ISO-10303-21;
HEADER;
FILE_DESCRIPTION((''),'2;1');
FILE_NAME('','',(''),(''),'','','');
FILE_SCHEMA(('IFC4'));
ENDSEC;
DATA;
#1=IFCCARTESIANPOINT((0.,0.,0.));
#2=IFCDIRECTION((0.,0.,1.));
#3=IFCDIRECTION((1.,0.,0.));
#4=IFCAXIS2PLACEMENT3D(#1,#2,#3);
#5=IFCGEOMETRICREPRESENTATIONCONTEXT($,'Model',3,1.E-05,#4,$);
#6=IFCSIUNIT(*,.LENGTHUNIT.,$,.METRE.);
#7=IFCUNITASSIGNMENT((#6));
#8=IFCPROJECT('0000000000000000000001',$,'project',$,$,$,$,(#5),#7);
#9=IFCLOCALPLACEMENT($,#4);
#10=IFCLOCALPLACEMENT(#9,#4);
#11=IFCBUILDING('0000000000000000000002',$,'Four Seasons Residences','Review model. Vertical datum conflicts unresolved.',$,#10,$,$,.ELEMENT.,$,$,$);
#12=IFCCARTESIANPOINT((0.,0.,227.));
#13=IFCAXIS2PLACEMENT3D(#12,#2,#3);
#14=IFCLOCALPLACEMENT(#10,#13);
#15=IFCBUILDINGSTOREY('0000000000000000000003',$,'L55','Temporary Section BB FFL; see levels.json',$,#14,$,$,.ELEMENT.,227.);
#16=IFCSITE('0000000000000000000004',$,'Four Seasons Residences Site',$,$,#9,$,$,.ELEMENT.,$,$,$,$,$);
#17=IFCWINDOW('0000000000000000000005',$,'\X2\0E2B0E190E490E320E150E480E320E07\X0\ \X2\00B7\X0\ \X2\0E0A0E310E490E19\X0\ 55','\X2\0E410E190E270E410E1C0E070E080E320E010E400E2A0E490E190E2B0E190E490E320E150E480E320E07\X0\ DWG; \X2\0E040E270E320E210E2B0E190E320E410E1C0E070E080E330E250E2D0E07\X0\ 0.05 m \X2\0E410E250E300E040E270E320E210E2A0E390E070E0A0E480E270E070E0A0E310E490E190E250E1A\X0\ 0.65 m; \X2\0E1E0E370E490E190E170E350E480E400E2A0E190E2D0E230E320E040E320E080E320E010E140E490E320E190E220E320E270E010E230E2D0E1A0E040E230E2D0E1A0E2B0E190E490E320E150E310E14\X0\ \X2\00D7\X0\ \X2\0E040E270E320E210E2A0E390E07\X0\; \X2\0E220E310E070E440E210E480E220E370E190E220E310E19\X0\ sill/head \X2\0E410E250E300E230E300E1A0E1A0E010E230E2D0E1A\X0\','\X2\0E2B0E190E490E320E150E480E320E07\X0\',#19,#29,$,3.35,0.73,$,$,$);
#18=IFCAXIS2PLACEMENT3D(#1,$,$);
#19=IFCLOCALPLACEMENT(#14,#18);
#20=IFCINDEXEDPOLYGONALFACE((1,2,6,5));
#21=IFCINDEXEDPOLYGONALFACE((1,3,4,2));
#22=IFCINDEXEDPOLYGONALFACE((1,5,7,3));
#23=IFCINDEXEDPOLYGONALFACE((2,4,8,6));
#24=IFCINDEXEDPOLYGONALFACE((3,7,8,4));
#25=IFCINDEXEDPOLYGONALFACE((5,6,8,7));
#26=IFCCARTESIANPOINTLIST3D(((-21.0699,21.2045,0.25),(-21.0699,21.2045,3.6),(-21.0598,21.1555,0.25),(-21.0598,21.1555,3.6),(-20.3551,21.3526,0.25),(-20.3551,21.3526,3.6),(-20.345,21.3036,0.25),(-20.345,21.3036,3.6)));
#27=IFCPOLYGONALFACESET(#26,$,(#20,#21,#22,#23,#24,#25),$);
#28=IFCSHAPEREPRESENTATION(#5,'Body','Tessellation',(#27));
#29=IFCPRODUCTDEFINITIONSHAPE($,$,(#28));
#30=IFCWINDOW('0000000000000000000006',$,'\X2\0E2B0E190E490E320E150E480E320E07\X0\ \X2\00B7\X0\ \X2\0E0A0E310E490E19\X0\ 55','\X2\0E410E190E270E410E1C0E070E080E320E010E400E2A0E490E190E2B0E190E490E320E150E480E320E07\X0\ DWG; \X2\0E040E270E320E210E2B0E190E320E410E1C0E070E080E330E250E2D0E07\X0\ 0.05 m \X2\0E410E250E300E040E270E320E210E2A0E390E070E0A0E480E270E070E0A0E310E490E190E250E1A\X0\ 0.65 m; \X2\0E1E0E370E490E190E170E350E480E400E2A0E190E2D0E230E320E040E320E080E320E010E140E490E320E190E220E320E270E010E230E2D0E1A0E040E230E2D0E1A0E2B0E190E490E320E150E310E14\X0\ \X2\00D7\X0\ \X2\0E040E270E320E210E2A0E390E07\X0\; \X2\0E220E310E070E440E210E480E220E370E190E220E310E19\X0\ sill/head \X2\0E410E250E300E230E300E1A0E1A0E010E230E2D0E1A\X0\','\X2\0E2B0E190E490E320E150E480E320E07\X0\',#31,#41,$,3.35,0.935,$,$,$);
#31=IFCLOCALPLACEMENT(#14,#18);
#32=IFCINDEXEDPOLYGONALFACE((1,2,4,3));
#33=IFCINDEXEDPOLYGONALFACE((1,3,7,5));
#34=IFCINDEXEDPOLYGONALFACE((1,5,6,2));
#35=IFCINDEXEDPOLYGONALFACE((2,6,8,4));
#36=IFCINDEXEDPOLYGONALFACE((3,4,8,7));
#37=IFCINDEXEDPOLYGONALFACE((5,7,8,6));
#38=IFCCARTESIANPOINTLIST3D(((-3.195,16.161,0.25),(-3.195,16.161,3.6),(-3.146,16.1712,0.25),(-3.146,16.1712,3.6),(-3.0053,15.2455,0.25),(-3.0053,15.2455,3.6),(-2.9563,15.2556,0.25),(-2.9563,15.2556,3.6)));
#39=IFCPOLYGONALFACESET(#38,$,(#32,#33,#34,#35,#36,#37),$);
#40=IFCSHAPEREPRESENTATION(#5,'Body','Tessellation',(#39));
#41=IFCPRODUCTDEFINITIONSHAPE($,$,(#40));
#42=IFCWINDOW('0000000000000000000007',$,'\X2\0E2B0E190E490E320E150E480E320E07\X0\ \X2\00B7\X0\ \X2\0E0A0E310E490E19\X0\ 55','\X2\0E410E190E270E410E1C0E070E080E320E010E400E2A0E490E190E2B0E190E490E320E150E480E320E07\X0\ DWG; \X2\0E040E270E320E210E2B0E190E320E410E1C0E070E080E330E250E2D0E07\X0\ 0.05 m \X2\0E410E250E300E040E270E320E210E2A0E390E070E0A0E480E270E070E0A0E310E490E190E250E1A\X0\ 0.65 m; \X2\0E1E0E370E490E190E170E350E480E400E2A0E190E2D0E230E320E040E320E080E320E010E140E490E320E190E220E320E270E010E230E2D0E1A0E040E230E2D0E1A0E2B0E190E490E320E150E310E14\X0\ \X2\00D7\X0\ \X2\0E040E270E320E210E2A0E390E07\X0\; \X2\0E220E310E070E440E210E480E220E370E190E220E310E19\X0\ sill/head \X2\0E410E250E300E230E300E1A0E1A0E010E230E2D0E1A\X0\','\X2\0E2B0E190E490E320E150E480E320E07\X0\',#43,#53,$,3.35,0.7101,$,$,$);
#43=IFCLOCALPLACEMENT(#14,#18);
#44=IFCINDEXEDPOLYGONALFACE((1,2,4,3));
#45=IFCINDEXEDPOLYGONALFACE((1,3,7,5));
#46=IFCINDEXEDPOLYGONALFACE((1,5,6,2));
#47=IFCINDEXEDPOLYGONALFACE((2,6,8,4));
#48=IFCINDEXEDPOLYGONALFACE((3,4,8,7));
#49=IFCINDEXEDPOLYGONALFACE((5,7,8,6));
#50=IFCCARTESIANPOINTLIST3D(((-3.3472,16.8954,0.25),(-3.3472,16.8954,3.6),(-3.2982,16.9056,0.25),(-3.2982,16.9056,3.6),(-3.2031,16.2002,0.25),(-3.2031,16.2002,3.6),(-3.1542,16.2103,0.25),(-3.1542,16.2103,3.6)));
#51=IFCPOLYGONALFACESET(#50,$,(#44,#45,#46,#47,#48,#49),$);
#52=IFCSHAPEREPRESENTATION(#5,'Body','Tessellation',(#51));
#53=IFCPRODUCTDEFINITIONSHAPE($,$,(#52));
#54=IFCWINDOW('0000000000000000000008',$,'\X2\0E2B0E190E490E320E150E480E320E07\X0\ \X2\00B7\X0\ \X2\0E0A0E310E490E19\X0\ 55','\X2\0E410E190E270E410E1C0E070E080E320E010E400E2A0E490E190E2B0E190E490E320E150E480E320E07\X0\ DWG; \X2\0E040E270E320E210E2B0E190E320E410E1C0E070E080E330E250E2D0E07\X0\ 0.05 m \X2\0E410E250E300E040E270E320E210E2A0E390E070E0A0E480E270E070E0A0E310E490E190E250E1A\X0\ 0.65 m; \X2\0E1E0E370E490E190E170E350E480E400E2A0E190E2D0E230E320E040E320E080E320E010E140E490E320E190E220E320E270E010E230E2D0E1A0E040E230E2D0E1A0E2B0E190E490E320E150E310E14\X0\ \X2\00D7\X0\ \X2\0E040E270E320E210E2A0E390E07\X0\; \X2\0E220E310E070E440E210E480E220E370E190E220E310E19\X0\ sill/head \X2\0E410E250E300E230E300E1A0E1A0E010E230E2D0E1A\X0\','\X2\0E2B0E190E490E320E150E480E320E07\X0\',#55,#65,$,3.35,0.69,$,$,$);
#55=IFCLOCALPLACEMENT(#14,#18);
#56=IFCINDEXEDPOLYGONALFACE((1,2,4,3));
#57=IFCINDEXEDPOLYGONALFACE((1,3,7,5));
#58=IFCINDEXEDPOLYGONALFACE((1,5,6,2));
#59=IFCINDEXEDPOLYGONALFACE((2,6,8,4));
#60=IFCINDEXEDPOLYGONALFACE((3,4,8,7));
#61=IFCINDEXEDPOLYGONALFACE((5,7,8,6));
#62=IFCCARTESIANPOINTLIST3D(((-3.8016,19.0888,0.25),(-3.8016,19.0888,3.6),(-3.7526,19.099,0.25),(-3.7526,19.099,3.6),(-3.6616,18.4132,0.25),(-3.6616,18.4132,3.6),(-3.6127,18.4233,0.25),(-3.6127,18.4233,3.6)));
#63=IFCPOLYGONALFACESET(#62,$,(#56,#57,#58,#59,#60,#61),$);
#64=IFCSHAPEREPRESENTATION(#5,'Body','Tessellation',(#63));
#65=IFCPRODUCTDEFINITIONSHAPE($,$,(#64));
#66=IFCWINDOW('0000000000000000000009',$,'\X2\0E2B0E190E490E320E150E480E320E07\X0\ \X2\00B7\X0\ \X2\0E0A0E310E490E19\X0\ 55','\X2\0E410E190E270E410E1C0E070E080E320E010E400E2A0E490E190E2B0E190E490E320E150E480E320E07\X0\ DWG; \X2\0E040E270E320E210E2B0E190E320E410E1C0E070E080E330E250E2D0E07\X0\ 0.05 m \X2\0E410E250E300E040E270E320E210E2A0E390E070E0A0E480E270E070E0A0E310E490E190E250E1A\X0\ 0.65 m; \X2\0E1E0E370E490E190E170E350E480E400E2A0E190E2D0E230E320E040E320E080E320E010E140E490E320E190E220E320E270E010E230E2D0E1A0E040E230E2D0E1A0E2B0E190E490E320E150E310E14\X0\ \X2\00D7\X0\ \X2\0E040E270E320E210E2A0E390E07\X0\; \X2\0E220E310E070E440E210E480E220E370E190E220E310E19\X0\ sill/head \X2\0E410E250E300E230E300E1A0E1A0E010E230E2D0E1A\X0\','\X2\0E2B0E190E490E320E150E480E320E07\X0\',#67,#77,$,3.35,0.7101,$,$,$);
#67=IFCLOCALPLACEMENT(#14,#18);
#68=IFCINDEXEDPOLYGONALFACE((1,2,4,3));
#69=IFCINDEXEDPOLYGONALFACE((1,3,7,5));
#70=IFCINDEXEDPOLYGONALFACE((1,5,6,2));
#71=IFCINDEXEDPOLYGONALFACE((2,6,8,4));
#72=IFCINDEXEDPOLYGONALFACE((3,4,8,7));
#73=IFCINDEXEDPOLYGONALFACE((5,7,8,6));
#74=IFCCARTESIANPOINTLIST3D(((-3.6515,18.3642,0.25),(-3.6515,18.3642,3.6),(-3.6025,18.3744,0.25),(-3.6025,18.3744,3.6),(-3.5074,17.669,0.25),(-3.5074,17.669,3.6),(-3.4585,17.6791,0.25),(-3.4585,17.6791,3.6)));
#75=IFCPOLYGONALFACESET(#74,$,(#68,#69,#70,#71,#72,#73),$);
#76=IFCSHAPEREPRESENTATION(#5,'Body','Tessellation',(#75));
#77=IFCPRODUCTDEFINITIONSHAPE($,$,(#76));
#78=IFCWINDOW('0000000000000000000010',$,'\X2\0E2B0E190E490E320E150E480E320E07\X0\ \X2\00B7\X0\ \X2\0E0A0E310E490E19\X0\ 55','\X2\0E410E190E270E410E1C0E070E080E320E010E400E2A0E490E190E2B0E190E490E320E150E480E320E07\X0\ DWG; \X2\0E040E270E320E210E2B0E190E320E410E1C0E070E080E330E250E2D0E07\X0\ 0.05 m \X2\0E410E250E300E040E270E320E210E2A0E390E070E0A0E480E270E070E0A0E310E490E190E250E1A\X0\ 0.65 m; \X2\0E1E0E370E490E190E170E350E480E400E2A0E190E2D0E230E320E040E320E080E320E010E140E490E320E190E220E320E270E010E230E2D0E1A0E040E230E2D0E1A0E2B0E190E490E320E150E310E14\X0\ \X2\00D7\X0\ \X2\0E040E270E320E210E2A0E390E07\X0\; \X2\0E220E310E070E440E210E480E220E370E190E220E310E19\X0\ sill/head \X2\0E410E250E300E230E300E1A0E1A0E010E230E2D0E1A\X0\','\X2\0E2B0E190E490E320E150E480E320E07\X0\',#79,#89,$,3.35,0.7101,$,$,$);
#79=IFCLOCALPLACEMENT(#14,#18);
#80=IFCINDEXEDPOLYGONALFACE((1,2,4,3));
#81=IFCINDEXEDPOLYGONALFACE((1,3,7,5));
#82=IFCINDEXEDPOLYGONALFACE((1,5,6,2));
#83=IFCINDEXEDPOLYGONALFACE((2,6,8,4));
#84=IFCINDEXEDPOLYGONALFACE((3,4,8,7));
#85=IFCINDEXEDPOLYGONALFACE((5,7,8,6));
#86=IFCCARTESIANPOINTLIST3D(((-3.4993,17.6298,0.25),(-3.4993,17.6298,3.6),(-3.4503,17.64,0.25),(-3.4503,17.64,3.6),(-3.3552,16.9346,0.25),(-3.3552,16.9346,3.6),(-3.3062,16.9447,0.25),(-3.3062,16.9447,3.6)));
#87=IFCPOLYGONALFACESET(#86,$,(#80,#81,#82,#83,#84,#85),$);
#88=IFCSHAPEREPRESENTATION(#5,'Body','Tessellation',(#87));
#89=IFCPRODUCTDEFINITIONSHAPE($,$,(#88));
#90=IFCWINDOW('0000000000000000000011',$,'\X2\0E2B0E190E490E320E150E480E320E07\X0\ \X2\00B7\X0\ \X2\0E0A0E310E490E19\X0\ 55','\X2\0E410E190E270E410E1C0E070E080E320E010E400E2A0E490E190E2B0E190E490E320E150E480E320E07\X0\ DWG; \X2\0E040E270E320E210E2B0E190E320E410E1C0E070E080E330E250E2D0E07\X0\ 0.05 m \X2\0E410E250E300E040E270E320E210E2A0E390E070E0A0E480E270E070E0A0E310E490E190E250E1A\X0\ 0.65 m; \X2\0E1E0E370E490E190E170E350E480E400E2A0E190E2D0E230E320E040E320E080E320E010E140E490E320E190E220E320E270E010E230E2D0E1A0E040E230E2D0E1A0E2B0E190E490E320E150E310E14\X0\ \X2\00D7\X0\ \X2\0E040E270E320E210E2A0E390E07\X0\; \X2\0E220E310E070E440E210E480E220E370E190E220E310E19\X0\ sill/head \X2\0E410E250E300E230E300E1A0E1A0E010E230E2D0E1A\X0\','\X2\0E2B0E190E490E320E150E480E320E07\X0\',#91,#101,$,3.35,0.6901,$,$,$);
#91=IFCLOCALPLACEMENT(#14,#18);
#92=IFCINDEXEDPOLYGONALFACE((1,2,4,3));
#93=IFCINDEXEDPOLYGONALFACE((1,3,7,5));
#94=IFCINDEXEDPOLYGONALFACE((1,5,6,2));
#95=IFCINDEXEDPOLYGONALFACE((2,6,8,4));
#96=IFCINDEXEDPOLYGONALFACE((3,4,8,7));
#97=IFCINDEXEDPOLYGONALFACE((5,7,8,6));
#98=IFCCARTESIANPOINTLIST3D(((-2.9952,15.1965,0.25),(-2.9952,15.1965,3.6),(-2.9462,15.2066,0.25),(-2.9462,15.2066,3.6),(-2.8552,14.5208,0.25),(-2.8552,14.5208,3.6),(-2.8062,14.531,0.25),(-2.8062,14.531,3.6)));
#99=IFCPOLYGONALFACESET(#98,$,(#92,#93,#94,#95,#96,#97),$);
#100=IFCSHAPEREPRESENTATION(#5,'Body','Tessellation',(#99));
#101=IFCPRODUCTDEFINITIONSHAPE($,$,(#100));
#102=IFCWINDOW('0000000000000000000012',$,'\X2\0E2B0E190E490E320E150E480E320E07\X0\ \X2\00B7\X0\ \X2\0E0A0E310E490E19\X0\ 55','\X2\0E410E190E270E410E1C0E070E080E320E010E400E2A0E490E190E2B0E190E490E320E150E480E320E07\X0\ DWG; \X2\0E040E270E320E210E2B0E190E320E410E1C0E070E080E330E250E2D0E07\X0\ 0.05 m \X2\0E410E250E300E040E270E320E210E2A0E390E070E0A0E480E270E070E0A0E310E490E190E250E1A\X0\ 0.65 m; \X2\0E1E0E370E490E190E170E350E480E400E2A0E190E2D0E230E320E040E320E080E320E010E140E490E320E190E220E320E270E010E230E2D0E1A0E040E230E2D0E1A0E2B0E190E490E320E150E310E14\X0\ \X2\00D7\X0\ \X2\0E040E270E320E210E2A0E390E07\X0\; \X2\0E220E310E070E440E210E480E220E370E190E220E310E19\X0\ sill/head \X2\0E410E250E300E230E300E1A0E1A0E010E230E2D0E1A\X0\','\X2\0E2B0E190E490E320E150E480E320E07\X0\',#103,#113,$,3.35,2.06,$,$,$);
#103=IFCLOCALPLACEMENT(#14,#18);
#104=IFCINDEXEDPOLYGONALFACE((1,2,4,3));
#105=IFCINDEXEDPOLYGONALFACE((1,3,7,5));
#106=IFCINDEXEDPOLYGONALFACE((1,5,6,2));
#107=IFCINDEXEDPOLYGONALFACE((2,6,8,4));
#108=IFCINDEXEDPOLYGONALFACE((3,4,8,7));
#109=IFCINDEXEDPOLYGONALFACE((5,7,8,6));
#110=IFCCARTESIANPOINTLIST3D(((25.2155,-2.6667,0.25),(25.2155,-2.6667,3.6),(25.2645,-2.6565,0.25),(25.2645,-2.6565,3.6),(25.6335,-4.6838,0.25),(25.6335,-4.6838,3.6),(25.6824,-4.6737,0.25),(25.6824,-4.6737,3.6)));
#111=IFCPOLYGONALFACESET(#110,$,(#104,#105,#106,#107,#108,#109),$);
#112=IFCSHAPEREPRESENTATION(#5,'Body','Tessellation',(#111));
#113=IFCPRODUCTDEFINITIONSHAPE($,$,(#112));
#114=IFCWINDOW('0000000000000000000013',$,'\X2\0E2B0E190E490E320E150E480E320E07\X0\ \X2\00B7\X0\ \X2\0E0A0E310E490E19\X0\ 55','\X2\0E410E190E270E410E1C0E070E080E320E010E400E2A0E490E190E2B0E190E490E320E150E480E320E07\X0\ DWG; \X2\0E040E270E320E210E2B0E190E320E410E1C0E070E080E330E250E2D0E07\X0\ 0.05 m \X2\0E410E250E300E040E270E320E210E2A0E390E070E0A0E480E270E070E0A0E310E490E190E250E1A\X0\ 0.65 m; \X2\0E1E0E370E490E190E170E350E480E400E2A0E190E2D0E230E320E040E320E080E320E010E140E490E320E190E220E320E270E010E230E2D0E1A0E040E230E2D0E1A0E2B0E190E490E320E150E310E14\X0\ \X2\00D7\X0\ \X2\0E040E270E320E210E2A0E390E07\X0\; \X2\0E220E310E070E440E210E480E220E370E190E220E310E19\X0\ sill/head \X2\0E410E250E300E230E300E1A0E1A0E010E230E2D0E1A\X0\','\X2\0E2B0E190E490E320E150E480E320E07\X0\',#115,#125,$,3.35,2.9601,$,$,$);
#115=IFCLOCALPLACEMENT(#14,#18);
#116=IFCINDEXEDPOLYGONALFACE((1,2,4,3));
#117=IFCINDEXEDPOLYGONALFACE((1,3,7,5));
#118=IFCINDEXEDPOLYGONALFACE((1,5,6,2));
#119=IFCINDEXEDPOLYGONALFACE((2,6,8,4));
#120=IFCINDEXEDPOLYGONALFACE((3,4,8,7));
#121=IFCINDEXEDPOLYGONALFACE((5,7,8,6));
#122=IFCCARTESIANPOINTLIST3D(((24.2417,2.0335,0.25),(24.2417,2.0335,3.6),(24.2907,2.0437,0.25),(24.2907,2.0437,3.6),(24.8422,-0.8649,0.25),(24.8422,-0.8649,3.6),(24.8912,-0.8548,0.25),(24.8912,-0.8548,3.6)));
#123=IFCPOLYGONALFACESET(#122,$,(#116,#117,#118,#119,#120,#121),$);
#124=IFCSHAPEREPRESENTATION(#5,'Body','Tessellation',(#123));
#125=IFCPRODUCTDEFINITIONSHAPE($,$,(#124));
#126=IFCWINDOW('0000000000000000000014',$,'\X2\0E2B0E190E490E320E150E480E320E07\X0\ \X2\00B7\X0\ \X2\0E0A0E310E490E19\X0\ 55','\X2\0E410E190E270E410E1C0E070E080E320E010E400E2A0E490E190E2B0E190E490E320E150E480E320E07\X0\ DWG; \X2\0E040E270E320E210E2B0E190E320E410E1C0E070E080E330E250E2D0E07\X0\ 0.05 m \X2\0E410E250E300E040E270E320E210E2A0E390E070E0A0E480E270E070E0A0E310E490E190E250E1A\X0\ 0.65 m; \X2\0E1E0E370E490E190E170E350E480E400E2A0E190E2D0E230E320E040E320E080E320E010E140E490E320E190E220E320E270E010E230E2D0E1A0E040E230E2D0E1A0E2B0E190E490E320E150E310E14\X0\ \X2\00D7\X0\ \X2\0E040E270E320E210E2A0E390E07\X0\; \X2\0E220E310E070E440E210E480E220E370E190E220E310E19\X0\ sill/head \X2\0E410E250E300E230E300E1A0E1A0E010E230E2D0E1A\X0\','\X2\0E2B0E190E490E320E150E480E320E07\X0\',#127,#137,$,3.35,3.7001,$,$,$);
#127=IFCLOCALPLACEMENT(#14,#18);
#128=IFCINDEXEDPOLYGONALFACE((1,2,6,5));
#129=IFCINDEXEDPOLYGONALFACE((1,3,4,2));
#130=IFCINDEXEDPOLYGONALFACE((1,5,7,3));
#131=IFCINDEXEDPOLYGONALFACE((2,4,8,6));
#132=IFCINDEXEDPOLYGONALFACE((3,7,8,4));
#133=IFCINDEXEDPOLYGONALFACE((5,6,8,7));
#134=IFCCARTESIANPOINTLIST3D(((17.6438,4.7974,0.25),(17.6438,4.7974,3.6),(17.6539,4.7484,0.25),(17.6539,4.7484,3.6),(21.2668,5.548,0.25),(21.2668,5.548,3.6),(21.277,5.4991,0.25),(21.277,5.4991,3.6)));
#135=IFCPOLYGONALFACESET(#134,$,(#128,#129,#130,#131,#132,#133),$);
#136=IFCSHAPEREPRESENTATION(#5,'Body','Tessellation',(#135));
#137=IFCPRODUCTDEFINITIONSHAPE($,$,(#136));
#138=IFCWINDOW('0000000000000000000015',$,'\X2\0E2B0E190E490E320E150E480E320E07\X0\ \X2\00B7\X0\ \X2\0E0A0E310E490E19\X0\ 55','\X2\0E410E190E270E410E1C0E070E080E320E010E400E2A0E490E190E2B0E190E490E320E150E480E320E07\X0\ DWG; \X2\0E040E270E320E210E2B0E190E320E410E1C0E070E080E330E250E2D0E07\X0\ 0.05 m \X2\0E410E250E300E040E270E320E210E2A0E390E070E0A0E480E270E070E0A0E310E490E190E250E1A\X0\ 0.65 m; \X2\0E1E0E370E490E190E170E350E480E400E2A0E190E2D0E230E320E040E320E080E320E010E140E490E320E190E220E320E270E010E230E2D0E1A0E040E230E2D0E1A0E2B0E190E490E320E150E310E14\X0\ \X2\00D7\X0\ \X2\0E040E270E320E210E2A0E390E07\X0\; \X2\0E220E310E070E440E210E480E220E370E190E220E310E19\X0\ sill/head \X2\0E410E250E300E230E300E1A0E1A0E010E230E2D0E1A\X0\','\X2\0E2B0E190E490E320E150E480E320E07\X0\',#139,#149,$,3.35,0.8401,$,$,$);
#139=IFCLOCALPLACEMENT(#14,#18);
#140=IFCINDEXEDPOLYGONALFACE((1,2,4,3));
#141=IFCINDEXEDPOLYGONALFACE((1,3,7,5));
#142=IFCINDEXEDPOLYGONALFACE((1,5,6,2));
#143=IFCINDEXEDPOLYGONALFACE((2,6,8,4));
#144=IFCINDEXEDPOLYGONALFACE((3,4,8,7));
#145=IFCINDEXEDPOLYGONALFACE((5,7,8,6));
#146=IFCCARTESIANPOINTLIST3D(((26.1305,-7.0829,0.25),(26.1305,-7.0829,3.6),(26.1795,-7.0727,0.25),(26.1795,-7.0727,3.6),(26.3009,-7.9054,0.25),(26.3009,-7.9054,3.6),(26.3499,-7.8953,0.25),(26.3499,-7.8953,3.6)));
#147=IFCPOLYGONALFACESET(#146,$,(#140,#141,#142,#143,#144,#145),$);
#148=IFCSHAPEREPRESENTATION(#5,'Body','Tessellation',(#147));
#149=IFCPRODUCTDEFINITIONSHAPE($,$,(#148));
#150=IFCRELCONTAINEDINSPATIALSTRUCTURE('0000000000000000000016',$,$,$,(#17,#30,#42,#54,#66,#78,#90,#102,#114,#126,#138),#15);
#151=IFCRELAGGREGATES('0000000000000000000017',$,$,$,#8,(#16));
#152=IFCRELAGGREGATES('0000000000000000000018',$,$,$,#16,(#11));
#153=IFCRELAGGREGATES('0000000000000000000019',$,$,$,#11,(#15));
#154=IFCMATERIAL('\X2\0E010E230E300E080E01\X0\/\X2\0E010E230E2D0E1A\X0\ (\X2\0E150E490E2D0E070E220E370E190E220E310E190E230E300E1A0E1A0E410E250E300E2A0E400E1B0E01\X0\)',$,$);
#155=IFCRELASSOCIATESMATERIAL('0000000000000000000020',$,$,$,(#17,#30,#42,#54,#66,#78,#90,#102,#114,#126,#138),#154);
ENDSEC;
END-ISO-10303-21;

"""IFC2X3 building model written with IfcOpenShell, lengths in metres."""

from ifc_helpers import new_model, si_unit, frame, origin_with_axes, place, context, project, spatial, polyline, outline, extrude, material, element, save


model = new_model("IFC2X3")

# Units and contexts
model_context = context("Model", 3, precision=1e-05, world=origin_with_axes())
ifc_project = project(units=[si_unit("LENGTHUNIT", "METRE")], contexts=[model_context])

# Site, building, storey
site_placement = place(None, origin_with_axes())
site = spatial("IfcSite", under=ifc_project, at=site_placement, Name="Four Seasons Residences Site", CompositionType="ELEMENT")
building_placement = place(site_placement, origin_with_axes())
building = spatial("IfcBuilding", under=site, at=building_placement, Name="Four Seasons Residences", Description="Review model. Vertical datum conflicts unresolved.", CompositionType="ELEMENT")
storey_placement = place(building_placement, frame((0.0, 0.0, 227.0), z_axis=(0.0, 0.0, 1.0), x_axis=(1.0, 0.0, 0.0)))
storey = spatial("IfcBuildingStorey", under=building, at=storey_placement, Name="L55", Description="Temporary Section BB FFL; see levels.json", CompositionType="ELEMENT", Elevation=227.0)

# Windows
ifc_material = material(Name="กระจก/กรอบ (ต้องยืนยันระบบและสเปก)")
window_1_placement = place(storey_placement, origin_with_axes())
element("IfcWindow", 1, at=window_1_placement, inside=storey, material=ifc_material, Name="หน้าต่าง · ชั้น 55", Description="แนวแผงจากเส้นหน้าต่าง DWG; ความหนาแผงจำลอง 0.05 m และความสูงช่วงชั้นลบ 0.65 m; พื้นที่เสนอราคาจากด้านยาวกรอบครอบหน้าตัด × ความสูง; ยังไม่ยืนยัน sill/head และระบบกรอบ", ObjectType="หน้าต่าง", OverallHeight=3.35, OverallWidth=0.73, context=model_context, shape_type="SweptSolid", body=[
    extrude(outline(polyline([(-21.0598, 21.1555), (-21.0699, 21.2045), (-20.3551, 21.3526), (-20.345, 21.3036), (-21.0598, 21.1555)])), frame((0.0, 0.0, 0.25), z_axis=(0.0, 0.0, 1.0), x_axis=(1.0, 0.0, 0.0)), (0.0, 0.0, 1.0), 3.35),
])
window_2_placement = place(storey_placement, origin_with_axes())
element("IfcWindow", 2, at=window_2_placement, inside=storey, material=ifc_material, Name="หน้าต่าง · ชั้น 55", Description="แนวแผงจากเส้นหน้าต่าง DWG; ความหนาแผงจำลอง 0.05 m และความสูงช่วงชั้นลบ 0.65 m; พื้นที่เสนอราคาจากด้านยาวกรอบครอบหน้าตัด × ความสูง; ยังไม่ยืนยัน sill/head และระบบกรอบ", ObjectType="หน้าต่าง", OverallHeight=3.35, OverallWidth=0.935, context=model_context, shape_type="SweptSolid", body=[
    extrude(outline(polyline([(-3.195, 16.161), (-3.146, 16.1712), (-2.9563, 15.2556), (-3.0053, 15.2455), (-3.195, 16.161)])), frame((0.0, 0.0, 0.25), z_axis=(0.0, 0.0, 1.0), x_axis=(1.0, 0.0, 0.0)), (0.0, 0.0, 1.0), 3.35),
])
window_3_placement = place(storey_placement, origin_with_axes())
element("IfcWindow", 3, at=window_3_placement, inside=storey, material=ifc_material, Name="หน้าต่าง · ชั้น 55", Description="แนวแผงจากเส้นหน้าต่าง DWG; ความหนาแผงจำลอง 0.05 m และความสูงช่วงชั้นลบ 0.65 m; พื้นที่เสนอราคาจากด้านยาวกรอบครอบหน้าตัด × ความสูง; ยังไม่ยืนยัน sill/head และระบบกรอบ", ObjectType="หน้าต่าง", OverallHeight=3.35, OverallWidth=0.7101, context=model_context, shape_type="SweptSolid", body=[
    extrude(outline(polyline([(-3.3472, 16.8954), (-3.2982, 16.9056), (-3.1542, 16.2103), (-3.2031, 16.2002), (-3.3472, 16.8954)])), frame((0.0, 0.0, 0.25), z_axis=(0.0, 0.0, 1.0), x_axis=(1.0, 0.0, 0.0)), (0.0, 0.0, 1.0), 3.35),
])
window_4_placement = place(storey_placement, origin_with_axes())
element("IfcWindow", 4, at=window_4_placement, inside=storey, material=ifc_material, Name="หน้าต่าง · ชั้น 55", Description="แนวแผงจากเส้นหน้าต่าง DWG; ความหนาแผงจำลอง 0.05 m และความสูงช่วงชั้นลบ 0.65 m; พื้นที่เสนอราคาจากด้านยาวกรอบครอบหน้าตัด × ความสูง; ยังไม่ยืนยัน sill/head และระบบกรอบ", ObjectType="หน้าต่าง", OverallHeight=3.35, OverallWidth=0.69, context=model_context, shape_type="SweptSolid", body=[
    extrude(outline(polyline([(-3.6127, 18.4233), (-3.6616, 18.4132), (-3.8016, 19.0888), (-3.7526, 19.099), (-3.6127, 18.4233)])), frame((0.0, 0.0, 0.25), z_axis=(0.0, 0.0, 1.0), x_axis=(1.0, 0.0, 0.0)), (0.0, 0.0, 1.0), 3.35),
])
window_5_placement = place(storey_placement, origin_with_axes())
element("IfcWindow", 5, at=window_5_placement, inside=storey, material=ifc_material, Name="หน้าต่าง · ชั้น 55", Description="แนวแผงจากเส้นหน้าต่าง DWG; ความหนาแผงจำลอง 0.05 m และความสูงช่วงชั้นลบ 0.65 m; พื้นที่เสนอราคาจากด้านยาวกรอบครอบหน้าตัด × ความสูง; ยังไม่ยืนยัน sill/head และระบบกรอบ", ObjectType="หน้าต่าง", OverallHeight=3.35, OverallWidth=0.7101, context=model_context, shape_type="SweptSolid", body=[
    extrude(outline(polyline([(-3.4585, 17.6791), (-3.5074, 17.669), (-3.6515, 18.3642), (-3.6025, 18.3744), (-3.4585, 17.6791)])), frame((0.0, 0.0, 0.25), z_axis=(0.0, 0.0, 1.0), x_axis=(1.0, 0.0, 0.0)), (0.0, 0.0, 1.0), 3.35),
])
window_6_placement = place(storey_placement, origin_with_axes())
element("IfcWindow", 6, at=window_6_placement, inside=storey, material=ifc_material, Name="หน้าต่าง · ชั้น 55", Description="แนวแผงจากเส้นหน้าต่าง DWG; ความหนาแผงจำลอง 0.05 m และความสูงช่วงชั้นลบ 0.65 m; พื้นที่เสนอราคาจากด้านยาวกรอบครอบหน้าตัด × ความสูง; ยังไม่ยืนยัน sill/head และระบบกรอบ", ObjectType="หน้าต่าง", OverallHeight=3.35, OverallWidth=0.7101, context=model_context, shape_type="SweptSolid", body=[
    extrude(outline(polyline([(-3.3062, 16.9447), (-3.3552, 16.9346), (-3.4993, 17.6298), (-3.4503, 17.64), (-3.3062, 16.9447)])), frame((0.0, 0.0, 0.25), z_axis=(0.0, 0.0, 1.0), x_axis=(1.0, 0.0, 0.0)), (0.0, 0.0, 1.0), 3.35),
])
window_7_placement = place(storey_placement, origin_with_axes())
element("IfcWindow", 7, at=window_7_placement, inside=storey, material=ifc_material, Name="หน้าต่าง · ชั้น 55", Description="แนวแผงจากเส้นหน้าต่าง DWG; ความหนาแผงจำลอง 0.05 m และความสูงช่วงชั้นลบ 0.65 m; พื้นที่เสนอราคาจากด้านยาวกรอบครอบหน้าตัด × ความสูง; ยังไม่ยืนยัน sill/head และระบบกรอบ", ObjectType="หน้าต่าง", OverallHeight=3.35, OverallWidth=0.6901, context=model_context, shape_type="SweptSolid", body=[
    extrude(outline(polyline([(-2.9952, 15.1965), (-2.9462, 15.2066), (-2.8062, 14.531), (-2.8552, 14.5208), (-2.9952, 15.1965)])), frame((0.0, 0.0, 0.25), z_axis=(0.0, 0.0, 1.0), x_axis=(1.0, 0.0, 0.0)), (0.0, 0.0, 1.0), 3.35),
])
window_8_placement = place(storey_placement, origin_with_axes())
element("IfcWindow", 8, at=window_8_placement, inside=storey, material=ifc_material, Name="หน้าต่าง · ชั้น 55", Description="แนวแผงจากเส้นหน้าต่าง DWG; ความหนาแผงจำลอง 0.05 m และความสูงช่วงชั้นลบ 0.65 m; พื้นที่เสนอราคาจากด้านยาวกรอบครอบหน้าตัด × ความสูง; ยังไม่ยืนยัน sill/head และระบบกรอบ", ObjectType="หน้าต่าง", OverallHeight=3.35, OverallWidth=2.06, context=model_context, shape_type="SweptSolid", body=[
    extrude(outline(polyline([(25.2155, -2.6667), (25.2645, -2.6565), (25.6824, -4.6737), (25.6335, -4.6838), (25.2155, -2.6667)])), frame((0.0, 0.0, 0.25), z_axis=(0.0, 0.0, 1.0), x_axis=(1.0, 0.0, 0.0)), (0.0, 0.0, 1.0), 3.35),
])
window_9_placement = place(storey_placement, origin_with_axes())
element("IfcWindow", 9, at=window_9_placement, inside=storey, material=ifc_material, Name="หน้าต่าง · ชั้น 55", Description="แนวแผงจากเส้นหน้าต่าง DWG; ความหนาแผงจำลอง 0.05 m และความสูงช่วงชั้นลบ 0.65 m; พื้นที่เสนอราคาจากด้านยาวกรอบครอบหน้าตัด × ความสูง; ยังไม่ยืนยัน sill/head และระบบกรอบ", ObjectType="หน้าต่าง", OverallHeight=3.35, OverallWidth=2.9601, context=model_context, shape_type="SweptSolid", body=[
    extrude(outline(polyline([(24.2417, 2.0335), (24.2907, 2.0437), (24.8912, -0.8548), (24.8422, -0.8649), (24.2417, 2.0335)])), frame((0.0, 0.0, 0.25), z_axis=(0.0, 0.0, 1.0), x_axis=(1.0, 0.0, 0.0)), (0.0, 0.0, 1.0), 3.35),
])
window_10_placement = place(storey_placement, origin_with_axes())
element("IfcWindow", 10, at=window_10_placement, inside=storey, material=ifc_material, Name="หน้าต่าง · ชั้น 55", Description="แนวแผงจากเส้นหน้าต่าง DWG; ความหนาแผงจำลอง 0.05 m และความสูงช่วงชั้นลบ 0.65 m; พื้นที่เสนอราคาจากด้านยาวกรอบครอบหน้าตัด × ความสูง; ยังไม่ยืนยัน sill/head และระบบกรอบ", ObjectType="หน้าต่าง", OverallHeight=3.35, OverallWidth=3.7001, context=model_context, shape_type="SweptSolid", body=[
    extrude(outline(polyline([(17.6539, 4.7484), (17.6438, 4.7974), (21.2668, 5.548), (21.277, 5.4991), (17.6539, 4.7484)])), frame((0.0, 0.0, 0.25), z_axis=(0.0, 0.0, 1.0), x_axis=(1.0, 0.0, 0.0)), (0.0, 0.0, 1.0), 3.35),
])
window_11_placement = place(storey_placement, origin_with_axes())
element("IfcWindow", 11, at=window_11_placement, inside=storey, material=ifc_material, Name="หน้าต่าง · ชั้น 55", Description="แนวแผงจากเส้นหน้าต่าง DWG; ความหนาแผงจำลอง 0.05 m และความสูงช่วงชั้นลบ 0.65 m; พื้นที่เสนอราคาจากด้านยาวกรอบครอบหน้าตัด × ความสูง; ยังไม่ยืนยัน sill/head และระบบกรอบ", ObjectType="หน้าต่าง", OverallHeight=3.35, OverallWidth=0.8401, context=model_context, shape_type="SweptSolid", body=[
    extrude(outline(polyline([(26.1305, -7.0829), (26.1795, -7.0727), (26.3499, -7.8953), (26.3009, -7.9054), (26.1305, -7.0829)])), frame((0.0, 0.0, 0.25), z_axis=(0.0, 0.0, 1.0), x_axis=(1.0, 0.0, 0.0)), (0.0, 0.0, 1.0), 3.35),
])

save(model, "model.ifc")
